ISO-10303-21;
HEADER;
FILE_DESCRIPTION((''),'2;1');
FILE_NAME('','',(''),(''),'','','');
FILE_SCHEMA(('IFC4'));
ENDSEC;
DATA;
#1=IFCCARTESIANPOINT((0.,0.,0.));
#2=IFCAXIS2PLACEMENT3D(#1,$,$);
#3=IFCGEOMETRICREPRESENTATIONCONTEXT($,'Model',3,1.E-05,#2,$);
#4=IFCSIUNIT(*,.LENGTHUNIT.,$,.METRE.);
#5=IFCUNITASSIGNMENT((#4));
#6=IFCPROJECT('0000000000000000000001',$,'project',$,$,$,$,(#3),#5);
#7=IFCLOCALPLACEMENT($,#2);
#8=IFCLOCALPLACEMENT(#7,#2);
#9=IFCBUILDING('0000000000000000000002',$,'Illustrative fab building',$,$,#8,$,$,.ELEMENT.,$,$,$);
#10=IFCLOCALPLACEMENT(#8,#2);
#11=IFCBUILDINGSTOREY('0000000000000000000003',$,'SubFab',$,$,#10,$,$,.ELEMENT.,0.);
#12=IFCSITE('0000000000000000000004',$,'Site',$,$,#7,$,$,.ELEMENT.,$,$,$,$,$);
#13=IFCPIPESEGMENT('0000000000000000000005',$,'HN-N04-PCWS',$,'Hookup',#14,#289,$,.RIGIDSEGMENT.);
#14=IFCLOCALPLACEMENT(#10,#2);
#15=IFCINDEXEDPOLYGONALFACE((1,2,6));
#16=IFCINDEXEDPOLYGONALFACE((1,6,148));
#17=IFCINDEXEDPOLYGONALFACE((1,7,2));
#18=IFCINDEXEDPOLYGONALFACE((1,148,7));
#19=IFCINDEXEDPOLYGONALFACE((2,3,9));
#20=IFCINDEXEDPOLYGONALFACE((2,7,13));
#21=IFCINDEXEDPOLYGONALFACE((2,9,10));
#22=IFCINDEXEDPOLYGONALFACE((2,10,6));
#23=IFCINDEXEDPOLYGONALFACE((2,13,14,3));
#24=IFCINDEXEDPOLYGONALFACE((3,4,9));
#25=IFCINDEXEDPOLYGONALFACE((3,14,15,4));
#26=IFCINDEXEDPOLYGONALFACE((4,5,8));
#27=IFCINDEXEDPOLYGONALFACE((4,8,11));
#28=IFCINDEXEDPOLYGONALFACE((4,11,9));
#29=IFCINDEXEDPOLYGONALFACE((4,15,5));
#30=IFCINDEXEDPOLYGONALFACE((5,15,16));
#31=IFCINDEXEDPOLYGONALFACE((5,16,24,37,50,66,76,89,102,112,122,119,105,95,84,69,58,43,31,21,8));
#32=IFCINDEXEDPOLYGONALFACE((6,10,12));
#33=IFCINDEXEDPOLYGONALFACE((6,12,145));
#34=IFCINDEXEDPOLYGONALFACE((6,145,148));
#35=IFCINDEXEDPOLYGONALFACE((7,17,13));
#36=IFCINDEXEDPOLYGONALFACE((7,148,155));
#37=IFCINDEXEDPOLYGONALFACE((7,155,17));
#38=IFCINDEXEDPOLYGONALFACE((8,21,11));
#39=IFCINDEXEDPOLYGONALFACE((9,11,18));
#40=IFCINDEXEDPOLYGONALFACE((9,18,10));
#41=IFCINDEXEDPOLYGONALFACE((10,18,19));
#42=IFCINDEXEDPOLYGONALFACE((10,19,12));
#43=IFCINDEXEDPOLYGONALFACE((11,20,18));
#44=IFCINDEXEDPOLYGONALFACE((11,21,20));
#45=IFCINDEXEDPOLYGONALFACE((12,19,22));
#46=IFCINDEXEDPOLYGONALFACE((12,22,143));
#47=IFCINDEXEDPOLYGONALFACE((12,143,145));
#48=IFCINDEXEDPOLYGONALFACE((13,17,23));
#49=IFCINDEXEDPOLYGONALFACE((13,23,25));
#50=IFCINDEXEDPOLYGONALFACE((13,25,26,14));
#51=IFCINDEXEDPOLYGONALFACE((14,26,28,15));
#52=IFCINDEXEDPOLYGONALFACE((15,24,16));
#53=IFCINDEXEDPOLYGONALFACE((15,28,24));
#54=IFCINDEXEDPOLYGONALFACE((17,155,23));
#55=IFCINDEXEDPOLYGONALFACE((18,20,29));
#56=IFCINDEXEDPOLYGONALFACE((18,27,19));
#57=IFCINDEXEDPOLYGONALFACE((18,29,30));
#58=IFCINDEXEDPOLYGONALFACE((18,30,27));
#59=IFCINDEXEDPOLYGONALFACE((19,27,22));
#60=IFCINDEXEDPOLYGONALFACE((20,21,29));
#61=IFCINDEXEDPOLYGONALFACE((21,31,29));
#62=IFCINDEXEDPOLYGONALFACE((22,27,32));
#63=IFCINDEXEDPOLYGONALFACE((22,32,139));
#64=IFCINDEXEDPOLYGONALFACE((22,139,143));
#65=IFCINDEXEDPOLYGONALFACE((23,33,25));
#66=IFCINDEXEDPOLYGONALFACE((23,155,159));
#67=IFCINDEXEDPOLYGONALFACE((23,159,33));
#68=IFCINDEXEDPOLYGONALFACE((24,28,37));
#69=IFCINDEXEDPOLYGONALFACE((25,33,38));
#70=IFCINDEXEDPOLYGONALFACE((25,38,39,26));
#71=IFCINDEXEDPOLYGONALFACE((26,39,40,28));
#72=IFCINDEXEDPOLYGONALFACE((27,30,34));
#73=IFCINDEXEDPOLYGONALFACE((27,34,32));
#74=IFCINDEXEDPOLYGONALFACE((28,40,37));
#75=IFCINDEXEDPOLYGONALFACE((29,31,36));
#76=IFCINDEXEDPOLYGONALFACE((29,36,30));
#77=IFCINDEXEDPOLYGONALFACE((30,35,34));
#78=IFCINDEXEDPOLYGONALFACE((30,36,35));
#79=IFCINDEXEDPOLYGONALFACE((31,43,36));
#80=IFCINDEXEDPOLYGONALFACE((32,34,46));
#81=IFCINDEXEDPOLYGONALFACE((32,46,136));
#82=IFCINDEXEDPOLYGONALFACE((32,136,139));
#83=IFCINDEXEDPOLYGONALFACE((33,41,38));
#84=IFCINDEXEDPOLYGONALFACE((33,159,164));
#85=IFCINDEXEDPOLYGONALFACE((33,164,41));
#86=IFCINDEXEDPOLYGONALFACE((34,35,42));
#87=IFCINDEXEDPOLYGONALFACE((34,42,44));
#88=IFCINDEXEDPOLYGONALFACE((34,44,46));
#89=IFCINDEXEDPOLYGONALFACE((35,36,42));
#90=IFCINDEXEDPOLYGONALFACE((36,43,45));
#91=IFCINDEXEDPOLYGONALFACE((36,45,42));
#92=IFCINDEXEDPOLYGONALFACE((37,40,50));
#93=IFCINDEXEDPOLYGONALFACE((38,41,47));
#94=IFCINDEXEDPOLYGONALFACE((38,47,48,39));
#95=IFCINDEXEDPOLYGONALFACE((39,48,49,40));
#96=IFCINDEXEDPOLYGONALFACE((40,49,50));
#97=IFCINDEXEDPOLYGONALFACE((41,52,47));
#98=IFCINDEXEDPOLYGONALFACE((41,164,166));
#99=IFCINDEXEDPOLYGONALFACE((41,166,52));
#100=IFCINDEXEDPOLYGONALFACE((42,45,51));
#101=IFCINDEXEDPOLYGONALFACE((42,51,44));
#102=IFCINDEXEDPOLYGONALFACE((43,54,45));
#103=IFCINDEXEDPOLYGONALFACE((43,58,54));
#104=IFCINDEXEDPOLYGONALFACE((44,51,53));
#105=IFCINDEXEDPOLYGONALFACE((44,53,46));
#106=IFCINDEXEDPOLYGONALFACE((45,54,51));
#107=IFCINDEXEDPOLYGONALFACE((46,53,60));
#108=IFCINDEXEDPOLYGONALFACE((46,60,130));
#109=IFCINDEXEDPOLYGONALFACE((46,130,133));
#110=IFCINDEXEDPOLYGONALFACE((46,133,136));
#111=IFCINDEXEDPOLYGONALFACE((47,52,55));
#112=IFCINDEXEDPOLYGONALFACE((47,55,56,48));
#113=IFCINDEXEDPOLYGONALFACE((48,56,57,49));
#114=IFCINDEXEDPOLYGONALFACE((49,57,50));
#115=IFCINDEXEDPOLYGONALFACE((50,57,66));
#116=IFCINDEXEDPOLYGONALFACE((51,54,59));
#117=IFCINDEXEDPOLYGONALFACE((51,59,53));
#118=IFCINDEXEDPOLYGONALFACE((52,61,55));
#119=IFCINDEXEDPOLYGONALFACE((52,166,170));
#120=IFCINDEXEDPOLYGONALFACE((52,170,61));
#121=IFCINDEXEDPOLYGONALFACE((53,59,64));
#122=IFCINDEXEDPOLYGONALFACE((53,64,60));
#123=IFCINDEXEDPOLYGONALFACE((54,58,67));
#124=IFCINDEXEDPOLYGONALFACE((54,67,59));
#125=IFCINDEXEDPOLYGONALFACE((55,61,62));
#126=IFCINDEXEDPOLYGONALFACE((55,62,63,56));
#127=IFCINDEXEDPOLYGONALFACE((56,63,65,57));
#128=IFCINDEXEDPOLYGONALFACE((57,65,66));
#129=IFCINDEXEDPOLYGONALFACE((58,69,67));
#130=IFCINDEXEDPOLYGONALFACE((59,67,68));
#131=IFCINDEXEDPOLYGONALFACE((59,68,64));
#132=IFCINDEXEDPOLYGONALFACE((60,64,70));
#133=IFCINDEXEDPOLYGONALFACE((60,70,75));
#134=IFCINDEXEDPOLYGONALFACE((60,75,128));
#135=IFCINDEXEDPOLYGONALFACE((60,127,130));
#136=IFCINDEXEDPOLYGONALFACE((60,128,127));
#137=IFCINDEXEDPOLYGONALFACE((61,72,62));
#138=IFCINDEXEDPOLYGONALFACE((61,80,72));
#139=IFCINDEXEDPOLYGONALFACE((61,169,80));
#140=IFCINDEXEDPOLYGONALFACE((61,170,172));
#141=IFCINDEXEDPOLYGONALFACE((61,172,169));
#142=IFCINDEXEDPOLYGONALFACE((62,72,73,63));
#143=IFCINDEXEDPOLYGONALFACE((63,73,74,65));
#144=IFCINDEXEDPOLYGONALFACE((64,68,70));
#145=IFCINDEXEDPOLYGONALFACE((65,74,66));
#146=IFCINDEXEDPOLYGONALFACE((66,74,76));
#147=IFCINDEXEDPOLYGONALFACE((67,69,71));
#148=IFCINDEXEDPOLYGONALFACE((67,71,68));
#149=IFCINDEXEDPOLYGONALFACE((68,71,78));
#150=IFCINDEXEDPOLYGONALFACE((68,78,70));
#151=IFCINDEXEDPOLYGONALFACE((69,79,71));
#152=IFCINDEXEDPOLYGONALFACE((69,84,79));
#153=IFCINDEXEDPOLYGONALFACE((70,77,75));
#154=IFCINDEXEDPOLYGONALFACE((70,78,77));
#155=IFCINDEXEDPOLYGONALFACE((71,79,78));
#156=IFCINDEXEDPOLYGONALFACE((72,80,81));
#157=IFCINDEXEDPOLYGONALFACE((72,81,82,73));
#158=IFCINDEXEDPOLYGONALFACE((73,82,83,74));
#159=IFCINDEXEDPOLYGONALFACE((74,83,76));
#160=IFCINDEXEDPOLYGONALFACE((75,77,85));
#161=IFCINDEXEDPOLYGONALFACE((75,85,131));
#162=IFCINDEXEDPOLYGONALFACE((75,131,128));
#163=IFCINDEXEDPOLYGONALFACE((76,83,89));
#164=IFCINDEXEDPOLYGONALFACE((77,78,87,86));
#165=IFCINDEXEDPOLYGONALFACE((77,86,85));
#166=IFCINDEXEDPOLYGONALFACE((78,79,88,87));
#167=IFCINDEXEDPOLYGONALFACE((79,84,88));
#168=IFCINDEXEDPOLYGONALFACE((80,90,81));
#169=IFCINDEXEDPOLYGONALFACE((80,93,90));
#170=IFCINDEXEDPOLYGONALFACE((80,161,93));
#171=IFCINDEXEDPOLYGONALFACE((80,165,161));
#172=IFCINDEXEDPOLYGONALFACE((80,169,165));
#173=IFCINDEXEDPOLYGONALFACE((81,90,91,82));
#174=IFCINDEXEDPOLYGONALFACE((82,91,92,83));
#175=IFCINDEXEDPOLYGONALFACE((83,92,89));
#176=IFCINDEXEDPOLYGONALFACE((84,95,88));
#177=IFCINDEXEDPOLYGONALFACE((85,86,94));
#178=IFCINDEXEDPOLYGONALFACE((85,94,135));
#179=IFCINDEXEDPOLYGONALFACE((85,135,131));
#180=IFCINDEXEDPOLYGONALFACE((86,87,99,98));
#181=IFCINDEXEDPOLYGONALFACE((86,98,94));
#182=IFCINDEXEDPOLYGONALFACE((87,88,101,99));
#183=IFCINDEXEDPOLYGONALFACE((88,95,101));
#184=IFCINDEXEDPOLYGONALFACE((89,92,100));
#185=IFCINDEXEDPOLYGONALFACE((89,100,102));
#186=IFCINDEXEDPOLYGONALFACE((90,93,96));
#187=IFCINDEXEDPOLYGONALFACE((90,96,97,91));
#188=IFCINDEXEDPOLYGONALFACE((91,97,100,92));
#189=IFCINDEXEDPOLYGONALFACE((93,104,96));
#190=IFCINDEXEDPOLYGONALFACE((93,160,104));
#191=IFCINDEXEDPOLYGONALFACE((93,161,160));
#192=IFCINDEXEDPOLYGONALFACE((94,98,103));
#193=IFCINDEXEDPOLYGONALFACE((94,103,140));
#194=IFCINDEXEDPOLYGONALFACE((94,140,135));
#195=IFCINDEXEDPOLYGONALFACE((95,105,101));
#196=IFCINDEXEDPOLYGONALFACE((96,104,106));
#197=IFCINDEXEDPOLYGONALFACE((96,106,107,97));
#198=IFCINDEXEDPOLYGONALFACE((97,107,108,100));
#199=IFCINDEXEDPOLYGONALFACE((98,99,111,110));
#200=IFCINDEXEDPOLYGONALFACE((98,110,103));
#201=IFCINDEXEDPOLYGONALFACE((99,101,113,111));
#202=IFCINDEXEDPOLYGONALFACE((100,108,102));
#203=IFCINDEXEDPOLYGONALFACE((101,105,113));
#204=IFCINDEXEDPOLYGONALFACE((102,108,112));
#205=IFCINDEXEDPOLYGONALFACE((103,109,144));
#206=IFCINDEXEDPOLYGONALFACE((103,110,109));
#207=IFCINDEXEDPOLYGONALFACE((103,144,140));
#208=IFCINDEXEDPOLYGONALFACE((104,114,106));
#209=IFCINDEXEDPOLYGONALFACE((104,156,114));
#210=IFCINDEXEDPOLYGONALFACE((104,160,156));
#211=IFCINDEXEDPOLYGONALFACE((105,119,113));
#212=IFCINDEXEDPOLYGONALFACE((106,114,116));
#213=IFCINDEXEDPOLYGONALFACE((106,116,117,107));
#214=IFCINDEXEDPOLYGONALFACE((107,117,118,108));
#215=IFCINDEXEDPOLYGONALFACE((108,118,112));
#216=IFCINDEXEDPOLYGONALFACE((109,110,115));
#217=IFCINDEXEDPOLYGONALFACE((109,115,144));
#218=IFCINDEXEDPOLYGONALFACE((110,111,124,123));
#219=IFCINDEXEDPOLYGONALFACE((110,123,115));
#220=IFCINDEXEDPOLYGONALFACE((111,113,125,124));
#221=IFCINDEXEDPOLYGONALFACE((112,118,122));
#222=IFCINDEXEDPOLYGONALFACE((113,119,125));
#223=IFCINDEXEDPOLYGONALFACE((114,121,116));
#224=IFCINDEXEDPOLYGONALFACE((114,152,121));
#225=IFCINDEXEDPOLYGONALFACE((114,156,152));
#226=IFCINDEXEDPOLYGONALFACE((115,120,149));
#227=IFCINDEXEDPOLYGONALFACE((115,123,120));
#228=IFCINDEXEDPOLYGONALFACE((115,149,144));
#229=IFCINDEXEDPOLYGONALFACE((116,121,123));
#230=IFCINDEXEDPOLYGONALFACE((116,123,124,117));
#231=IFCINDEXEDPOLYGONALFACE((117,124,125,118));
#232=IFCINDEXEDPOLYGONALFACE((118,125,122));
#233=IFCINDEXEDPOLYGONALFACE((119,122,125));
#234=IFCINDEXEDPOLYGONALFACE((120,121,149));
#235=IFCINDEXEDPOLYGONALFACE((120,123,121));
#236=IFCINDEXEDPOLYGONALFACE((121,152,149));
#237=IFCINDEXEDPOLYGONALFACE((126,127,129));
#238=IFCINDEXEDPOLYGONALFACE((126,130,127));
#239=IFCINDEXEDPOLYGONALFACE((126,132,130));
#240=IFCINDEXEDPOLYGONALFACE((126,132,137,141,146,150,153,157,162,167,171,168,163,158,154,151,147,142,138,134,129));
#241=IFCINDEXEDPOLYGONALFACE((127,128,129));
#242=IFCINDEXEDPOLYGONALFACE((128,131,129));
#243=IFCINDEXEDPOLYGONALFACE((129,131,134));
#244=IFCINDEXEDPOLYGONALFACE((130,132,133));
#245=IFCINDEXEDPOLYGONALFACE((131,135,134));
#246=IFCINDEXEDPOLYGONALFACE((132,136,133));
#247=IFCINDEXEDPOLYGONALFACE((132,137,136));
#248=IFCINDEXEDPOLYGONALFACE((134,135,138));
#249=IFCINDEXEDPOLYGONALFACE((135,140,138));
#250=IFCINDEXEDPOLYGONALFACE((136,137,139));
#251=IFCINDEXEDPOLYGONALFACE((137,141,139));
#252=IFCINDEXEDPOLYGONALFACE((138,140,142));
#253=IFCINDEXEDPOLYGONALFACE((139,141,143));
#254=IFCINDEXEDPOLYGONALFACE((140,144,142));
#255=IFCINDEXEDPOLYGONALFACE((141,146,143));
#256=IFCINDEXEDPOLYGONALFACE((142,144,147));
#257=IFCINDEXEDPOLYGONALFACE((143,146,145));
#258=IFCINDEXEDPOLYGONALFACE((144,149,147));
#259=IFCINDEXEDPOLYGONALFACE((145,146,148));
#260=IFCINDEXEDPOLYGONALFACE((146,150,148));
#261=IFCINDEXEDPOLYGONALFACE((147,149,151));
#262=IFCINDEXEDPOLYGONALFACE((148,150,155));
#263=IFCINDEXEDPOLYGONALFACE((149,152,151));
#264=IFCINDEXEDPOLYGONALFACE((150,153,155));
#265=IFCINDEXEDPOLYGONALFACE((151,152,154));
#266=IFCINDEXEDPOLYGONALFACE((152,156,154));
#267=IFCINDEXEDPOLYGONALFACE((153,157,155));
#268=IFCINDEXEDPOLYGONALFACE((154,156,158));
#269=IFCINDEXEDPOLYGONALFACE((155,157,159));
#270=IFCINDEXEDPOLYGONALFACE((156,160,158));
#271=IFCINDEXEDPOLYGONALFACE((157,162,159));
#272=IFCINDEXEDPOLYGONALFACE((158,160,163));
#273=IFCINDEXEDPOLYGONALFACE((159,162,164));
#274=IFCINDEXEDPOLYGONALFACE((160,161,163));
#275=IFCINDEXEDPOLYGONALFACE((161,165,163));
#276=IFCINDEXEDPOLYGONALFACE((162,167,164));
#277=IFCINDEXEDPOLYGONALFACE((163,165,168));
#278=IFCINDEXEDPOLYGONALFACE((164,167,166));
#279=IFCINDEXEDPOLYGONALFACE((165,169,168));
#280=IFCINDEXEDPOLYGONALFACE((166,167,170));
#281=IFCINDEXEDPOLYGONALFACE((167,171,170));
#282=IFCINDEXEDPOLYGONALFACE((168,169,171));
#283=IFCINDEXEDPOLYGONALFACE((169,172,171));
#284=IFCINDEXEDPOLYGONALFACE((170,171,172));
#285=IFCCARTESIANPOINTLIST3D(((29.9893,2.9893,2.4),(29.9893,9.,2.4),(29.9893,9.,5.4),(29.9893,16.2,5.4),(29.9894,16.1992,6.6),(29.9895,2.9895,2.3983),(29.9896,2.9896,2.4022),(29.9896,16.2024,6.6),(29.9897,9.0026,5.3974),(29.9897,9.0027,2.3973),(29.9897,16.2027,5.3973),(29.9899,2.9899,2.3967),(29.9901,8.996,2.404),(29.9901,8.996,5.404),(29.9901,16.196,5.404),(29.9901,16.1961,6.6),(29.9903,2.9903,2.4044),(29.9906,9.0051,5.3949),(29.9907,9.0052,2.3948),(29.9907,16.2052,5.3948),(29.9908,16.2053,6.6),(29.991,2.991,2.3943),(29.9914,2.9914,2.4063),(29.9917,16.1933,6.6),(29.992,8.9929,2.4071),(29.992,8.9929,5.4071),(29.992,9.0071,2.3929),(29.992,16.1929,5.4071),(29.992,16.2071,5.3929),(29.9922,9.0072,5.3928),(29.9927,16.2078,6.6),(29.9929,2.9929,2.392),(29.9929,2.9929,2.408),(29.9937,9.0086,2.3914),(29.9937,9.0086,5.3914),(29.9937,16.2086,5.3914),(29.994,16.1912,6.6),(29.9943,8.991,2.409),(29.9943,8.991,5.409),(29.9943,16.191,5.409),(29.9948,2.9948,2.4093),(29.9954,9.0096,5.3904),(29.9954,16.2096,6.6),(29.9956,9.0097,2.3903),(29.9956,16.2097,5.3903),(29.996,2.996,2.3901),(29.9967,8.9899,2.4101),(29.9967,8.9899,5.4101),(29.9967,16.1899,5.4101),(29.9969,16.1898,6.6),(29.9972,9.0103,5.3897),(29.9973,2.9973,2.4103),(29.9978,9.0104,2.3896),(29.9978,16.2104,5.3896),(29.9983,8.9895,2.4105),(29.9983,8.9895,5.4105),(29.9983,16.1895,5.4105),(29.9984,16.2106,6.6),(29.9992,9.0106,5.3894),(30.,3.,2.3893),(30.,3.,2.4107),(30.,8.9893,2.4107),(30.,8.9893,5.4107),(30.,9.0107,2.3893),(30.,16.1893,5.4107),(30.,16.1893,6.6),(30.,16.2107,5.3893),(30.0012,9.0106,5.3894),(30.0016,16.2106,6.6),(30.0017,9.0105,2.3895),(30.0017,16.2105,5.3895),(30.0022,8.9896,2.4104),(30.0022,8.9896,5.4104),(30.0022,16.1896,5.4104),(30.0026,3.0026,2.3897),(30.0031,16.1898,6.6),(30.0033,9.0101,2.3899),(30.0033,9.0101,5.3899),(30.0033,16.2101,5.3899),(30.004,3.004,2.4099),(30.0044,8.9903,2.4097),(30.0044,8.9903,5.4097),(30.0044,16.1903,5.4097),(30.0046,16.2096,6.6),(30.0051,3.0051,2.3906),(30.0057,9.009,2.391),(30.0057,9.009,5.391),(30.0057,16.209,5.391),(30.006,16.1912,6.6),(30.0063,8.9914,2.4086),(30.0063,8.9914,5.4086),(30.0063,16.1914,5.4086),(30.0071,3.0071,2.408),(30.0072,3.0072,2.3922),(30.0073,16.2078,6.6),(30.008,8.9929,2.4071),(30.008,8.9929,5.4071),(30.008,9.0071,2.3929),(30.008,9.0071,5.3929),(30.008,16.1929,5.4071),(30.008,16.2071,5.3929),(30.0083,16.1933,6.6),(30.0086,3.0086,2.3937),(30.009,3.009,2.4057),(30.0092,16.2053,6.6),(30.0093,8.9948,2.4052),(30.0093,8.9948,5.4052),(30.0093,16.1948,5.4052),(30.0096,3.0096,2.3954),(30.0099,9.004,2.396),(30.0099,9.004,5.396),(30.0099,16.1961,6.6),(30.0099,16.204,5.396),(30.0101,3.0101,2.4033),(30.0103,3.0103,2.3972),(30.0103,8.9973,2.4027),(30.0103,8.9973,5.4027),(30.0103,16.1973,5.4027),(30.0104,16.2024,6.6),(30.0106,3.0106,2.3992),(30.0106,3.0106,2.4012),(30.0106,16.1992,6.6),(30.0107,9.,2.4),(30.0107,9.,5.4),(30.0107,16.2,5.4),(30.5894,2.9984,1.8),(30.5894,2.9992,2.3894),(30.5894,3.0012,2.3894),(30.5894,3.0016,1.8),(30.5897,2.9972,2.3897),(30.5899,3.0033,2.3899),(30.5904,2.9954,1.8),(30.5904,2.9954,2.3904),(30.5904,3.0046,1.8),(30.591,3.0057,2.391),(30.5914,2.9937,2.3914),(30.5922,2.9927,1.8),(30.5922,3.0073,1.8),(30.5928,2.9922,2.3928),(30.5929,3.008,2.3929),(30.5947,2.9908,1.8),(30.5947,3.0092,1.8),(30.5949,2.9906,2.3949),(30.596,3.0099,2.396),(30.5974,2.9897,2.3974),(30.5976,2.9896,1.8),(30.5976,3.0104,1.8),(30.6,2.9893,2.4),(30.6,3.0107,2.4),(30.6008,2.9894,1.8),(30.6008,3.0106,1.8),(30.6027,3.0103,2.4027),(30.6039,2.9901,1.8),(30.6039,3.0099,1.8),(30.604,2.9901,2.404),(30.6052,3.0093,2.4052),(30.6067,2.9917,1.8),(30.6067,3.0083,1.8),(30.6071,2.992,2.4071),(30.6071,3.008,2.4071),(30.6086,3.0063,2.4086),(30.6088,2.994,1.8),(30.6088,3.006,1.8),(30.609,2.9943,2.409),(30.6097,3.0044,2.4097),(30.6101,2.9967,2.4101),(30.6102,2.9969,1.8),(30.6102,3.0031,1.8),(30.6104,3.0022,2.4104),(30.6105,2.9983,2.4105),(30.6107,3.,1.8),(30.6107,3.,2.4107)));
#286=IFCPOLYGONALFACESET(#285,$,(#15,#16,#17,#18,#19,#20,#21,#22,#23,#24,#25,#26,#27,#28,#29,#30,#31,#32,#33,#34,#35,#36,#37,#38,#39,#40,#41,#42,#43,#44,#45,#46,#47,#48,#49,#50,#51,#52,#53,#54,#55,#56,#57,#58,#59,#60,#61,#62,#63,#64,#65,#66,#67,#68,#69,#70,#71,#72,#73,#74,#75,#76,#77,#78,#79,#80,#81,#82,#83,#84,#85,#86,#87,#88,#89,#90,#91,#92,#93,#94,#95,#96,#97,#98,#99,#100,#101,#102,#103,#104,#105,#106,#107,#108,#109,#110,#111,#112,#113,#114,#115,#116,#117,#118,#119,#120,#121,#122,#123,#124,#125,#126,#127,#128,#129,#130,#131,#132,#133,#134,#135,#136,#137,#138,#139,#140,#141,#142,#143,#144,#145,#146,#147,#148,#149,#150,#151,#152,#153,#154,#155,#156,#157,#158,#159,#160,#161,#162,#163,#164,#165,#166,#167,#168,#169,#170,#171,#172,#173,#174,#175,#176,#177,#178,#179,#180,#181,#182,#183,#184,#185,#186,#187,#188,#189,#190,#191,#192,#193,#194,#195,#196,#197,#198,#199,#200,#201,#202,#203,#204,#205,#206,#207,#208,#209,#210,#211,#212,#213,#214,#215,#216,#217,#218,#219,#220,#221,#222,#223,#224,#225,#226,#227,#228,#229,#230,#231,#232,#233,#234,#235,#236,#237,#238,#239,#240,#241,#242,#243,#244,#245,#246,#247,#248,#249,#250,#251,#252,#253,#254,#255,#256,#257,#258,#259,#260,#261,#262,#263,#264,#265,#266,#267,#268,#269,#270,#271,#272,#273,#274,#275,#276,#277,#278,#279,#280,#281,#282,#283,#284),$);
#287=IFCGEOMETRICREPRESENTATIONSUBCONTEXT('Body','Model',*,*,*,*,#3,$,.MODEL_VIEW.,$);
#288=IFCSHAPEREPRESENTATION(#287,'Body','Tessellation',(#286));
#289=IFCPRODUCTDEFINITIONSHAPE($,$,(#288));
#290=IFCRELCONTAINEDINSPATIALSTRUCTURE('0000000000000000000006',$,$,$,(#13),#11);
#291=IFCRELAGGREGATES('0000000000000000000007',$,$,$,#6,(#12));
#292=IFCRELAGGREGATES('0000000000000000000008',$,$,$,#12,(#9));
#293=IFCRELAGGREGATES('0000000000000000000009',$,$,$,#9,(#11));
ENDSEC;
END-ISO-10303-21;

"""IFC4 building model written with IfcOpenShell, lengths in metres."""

from ifc_helpers import new_model, entity, si_unit, origin, place, context, subcontext, project, spatial, element, save


model = new_model("IFC4")

# Units and contexts
model_context = context("Model", 3, precision=1e-05, world=origin())
body_context = subcontext(model_context, "Body", "Model", "MODEL_VIEW")
ifc_project = project(units=[si_unit("LENGTHUNIT", "METRE")], contexts=[model_context])

# Site, building, storey
site_placement = place(None, origin())
site = spatial("IfcSite", under=ifc_project, at=site_placement, Name="Site", CompositionType="ELEMENT")
building_placement = place(site_placement, origin())
building = spatial("IfcBuilding", under=site, at=building_placement, Name="Illustrative fab building", CompositionType="ELEMENT")
storey_placement = place(building_placement, origin())
storey = spatial("IfcBuildingStorey", under=building, at=storey_placement, Name="SubFab", CompositionType="ELEMENT", Elevation=0.0)

# Pipe segment
pipe_segment_1_placement = place(storey_placement, origin())
element("IfcPipeSegment", 1, at=pipe_segment_1_placement, inside=storey, Name="HN-N04-PCWS", ObjectType="Hookup", PredefinedType="RIGIDSEGMENT", context=body_context, shape_type="AdvancedSweptSolid", body=[
    entity("IfcSweptDiskSolid", entity("IfcPolyline", [entity("IfcCartesianPoint", [30.6, 3.0, 1.8]), entity("IfcCartesianPoint", [30.6, 3.0, 2.4]), entity("IfcCartesianPoint", [30.0, 3.0, 2.4]), entity("IfcCartesianPoint", [30.0, 9.0, 2.4]), entity("IfcCartesianPoint", [30.0, 9.0, 5.4]), entity("IfcCartesianPoint", [30.0, 16.2, 5.4]), entity("IfcCartesianPoint", [30.0, 16.2, 6.6])]), 0.0107),
])

save(model, "model.ifc")
